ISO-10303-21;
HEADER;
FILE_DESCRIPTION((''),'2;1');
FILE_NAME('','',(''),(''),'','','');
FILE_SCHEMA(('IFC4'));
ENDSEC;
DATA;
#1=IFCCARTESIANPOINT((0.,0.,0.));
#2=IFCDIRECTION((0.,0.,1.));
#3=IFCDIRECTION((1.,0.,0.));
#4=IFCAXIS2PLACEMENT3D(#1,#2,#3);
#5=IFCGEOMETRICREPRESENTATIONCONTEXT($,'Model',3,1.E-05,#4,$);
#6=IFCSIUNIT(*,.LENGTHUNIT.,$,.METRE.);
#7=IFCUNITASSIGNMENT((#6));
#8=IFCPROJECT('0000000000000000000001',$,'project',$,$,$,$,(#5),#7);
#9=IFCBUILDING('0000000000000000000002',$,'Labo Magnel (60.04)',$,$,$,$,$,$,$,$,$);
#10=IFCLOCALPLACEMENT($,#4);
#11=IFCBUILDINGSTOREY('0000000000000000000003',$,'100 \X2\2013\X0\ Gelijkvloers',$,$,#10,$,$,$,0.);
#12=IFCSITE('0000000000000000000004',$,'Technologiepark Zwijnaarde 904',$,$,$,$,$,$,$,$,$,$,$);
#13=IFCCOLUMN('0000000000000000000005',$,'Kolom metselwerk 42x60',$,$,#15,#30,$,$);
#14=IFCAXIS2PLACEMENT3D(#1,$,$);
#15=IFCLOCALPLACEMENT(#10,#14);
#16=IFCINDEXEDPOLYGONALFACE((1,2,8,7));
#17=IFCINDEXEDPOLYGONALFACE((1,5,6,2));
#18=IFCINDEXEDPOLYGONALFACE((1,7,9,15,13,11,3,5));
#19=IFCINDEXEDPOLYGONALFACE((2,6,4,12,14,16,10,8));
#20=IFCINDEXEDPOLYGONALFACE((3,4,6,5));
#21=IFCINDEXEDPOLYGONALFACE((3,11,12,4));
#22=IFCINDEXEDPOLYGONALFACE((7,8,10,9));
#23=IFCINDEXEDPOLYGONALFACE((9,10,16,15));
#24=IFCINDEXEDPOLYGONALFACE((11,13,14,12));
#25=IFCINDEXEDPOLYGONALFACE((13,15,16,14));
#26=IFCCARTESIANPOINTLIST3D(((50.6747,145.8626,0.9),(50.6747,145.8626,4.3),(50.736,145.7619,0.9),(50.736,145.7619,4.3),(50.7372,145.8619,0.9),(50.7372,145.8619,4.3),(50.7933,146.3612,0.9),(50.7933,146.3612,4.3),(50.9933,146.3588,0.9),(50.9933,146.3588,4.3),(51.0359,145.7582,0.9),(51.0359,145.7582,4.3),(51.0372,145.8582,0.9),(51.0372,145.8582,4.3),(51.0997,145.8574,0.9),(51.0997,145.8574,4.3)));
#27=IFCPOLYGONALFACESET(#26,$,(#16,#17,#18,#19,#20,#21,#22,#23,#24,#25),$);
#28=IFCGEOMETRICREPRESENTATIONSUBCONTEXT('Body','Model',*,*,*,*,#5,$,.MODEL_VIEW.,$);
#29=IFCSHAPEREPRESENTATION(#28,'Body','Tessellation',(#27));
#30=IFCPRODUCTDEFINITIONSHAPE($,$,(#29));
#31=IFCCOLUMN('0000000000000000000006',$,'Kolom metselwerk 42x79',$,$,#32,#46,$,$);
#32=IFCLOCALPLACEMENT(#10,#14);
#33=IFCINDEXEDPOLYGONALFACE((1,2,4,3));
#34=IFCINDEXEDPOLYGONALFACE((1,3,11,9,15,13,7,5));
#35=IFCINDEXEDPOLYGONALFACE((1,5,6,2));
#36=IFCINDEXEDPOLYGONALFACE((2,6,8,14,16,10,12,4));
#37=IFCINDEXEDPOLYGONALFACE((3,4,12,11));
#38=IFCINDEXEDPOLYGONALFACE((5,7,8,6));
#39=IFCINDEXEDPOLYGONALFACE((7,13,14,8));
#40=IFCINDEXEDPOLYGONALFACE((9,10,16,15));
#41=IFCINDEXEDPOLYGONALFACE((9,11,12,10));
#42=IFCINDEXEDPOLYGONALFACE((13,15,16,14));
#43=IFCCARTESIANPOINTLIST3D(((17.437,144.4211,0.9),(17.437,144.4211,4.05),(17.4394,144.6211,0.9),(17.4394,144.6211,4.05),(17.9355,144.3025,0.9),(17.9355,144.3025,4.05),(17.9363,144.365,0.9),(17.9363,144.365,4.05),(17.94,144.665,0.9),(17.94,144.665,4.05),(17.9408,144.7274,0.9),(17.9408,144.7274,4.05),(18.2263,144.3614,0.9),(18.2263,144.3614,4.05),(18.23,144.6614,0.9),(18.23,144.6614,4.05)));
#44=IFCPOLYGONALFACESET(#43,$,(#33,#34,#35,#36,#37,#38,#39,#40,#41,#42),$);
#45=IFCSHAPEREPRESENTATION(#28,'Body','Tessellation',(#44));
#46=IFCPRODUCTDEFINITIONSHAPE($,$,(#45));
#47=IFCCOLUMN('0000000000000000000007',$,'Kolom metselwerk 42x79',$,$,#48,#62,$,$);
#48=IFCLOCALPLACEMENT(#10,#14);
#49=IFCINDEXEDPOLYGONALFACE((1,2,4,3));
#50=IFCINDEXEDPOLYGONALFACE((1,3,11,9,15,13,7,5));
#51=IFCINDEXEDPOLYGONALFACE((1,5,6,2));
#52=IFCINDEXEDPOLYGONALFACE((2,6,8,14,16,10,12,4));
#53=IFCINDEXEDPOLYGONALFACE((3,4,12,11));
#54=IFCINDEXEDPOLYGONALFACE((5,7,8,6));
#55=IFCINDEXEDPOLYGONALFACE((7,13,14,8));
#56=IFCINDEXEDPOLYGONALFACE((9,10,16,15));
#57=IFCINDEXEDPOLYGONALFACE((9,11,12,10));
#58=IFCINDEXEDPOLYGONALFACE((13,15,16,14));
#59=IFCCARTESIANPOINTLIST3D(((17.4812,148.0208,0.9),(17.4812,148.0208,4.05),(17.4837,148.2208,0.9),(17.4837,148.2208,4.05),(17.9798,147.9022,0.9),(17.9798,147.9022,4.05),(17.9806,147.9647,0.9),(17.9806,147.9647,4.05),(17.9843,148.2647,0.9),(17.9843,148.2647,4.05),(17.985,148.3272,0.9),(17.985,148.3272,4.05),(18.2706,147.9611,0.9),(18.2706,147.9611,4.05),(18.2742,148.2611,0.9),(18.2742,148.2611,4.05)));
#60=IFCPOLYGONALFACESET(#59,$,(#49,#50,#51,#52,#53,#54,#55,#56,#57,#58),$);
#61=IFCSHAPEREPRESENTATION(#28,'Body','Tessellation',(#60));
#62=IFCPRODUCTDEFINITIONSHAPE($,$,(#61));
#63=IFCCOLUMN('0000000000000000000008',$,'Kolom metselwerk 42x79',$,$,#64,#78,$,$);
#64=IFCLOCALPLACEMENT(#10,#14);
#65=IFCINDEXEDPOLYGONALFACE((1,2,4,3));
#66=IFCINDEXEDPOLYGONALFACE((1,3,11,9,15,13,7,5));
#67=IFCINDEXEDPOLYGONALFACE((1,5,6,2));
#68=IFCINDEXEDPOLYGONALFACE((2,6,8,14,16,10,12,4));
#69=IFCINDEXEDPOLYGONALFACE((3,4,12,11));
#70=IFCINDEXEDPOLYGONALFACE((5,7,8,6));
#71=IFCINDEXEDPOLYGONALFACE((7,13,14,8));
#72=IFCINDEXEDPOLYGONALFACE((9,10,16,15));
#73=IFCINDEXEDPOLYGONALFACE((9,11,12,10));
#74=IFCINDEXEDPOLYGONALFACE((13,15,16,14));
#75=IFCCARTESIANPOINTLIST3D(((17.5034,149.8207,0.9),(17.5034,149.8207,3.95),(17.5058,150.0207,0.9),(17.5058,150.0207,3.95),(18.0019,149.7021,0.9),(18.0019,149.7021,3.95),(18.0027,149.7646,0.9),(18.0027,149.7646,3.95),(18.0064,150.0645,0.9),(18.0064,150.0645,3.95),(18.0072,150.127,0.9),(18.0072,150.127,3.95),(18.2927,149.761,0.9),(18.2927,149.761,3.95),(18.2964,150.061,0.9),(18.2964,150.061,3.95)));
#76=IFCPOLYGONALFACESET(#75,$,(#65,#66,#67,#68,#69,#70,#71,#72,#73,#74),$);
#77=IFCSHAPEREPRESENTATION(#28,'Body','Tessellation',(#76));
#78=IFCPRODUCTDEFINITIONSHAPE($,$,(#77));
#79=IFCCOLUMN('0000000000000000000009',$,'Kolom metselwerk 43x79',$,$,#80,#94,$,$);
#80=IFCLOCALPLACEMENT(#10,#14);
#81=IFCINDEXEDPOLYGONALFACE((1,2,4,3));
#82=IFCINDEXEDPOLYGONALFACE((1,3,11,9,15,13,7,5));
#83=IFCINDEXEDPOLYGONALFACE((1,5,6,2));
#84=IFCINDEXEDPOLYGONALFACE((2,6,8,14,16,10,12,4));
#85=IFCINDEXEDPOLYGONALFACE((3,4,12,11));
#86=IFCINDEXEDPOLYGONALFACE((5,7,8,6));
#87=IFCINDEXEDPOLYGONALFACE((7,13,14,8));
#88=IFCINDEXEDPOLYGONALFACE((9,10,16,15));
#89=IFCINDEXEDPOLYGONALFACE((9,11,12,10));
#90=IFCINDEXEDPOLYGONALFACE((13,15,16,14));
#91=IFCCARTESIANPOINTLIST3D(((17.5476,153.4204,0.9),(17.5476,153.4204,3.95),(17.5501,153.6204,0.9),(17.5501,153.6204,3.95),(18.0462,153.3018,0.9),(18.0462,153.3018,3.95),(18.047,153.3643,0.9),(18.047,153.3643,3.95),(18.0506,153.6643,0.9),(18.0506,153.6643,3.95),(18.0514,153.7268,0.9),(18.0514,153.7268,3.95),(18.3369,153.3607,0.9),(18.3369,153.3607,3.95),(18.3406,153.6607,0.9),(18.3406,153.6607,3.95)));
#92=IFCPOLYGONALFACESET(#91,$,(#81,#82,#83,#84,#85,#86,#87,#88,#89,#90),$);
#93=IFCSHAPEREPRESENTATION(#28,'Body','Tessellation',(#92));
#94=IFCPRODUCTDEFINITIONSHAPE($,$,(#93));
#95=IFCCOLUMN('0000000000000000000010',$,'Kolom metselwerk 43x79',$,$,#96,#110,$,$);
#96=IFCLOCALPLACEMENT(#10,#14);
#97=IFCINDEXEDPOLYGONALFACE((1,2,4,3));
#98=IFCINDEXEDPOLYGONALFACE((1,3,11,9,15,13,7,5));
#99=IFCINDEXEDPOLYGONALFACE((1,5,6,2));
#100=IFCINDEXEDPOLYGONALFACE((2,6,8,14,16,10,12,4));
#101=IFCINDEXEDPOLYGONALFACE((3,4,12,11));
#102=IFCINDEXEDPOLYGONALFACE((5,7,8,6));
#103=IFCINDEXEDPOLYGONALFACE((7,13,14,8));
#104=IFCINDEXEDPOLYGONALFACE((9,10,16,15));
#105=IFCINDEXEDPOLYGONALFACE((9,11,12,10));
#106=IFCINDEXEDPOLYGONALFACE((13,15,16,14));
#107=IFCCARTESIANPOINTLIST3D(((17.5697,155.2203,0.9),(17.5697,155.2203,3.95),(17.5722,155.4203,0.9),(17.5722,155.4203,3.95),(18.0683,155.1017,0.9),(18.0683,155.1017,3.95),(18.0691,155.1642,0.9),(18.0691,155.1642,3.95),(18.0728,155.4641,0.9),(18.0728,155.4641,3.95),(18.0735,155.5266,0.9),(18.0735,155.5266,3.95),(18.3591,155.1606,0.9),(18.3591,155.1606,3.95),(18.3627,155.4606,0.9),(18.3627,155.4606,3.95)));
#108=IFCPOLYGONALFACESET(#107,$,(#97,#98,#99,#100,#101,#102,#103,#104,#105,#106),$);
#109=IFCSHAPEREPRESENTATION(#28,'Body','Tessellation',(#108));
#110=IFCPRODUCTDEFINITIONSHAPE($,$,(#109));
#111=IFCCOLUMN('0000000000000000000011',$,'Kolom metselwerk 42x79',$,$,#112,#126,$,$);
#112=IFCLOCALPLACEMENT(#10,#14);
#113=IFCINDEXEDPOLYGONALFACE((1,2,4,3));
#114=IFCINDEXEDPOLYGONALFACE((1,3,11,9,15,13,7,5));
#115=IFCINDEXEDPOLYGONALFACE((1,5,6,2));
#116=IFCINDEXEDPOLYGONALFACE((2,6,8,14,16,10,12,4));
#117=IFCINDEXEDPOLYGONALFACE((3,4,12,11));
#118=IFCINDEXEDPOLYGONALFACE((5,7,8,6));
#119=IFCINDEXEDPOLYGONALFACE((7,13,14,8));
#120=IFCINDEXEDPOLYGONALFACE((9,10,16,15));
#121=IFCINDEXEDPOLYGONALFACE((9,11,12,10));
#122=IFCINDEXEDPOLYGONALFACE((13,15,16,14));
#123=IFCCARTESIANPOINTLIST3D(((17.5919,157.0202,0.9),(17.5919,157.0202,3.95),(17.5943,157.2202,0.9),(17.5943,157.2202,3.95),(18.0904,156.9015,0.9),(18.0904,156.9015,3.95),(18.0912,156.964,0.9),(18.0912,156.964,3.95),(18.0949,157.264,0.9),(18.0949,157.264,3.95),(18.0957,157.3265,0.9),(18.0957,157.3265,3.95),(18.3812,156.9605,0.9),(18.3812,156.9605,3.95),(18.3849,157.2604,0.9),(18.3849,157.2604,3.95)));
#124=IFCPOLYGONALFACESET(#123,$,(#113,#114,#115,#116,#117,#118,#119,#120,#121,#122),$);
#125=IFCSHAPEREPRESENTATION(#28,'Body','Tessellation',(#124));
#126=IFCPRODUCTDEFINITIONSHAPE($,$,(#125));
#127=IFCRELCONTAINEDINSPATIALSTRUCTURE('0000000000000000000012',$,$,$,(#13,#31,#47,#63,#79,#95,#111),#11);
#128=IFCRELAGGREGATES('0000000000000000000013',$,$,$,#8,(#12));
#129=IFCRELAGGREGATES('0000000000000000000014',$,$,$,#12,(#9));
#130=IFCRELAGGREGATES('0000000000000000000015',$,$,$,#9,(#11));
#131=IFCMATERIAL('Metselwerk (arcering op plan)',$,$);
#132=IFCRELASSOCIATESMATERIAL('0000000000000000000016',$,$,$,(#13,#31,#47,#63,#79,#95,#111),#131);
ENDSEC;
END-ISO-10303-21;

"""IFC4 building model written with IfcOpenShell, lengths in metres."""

from ifc_helpers import new_model, si_unit, frame, origin, origin_with_axes, place, context, subcontext, project, spatial, polyline, outline, extrude, material, element, save


model = new_model("IFC4")

# Units and contexts
model_context = context("Model", 3, precision=1e-05, world=origin_with_axes())
body_context = subcontext(model_context, "Body", "Model", "MODEL_VIEW")
ifc_project = project(units=[si_unit("LENGTHUNIT", "METRE")], contexts=[model_context])

# Site, building, storey
site = spatial("IfcSite", under=ifc_project, Name="Technologiepark Zwijnaarde 904")
building = spatial("IfcBuilding", under=site, Name="Labo Magnel (60.04)")
storey_placement = place(None, origin_with_axes())
storey = spatial("IfcBuildingStorey", under=building, at=storey_placement, Name="100 – Gelijkvloers", Elevation=0.0)

# Columns
ifc_material_1 = material(Name="Metselwerk (arcering op plan)")
column_1_placement = place(storey_placement, frame((0.0, 0.0, 0.9), z_axis=(0.0, 0.0, 1.0), x_axis=(1.0, 0.0, 0.0)))
element("IfcColumn", 1, at=column_1_placement, inside=storey, material=ifc_material_1, Name="Kolom metselwerk 42x60", context=body_context, shape_type="SweptSolid", body=[
    extrude(outline(polyline([(50.9933, 146.3588), (50.7933, 146.3612), (50.6747, 145.8626), (50.7372, 145.8619), (50.736, 145.7619), (51.0359, 145.7582), (51.0372, 145.8582), (51.0997, 145.8574), (50.9933, 146.3588)])), origin(), (0.0, 0.0, 1.0), 3.4),
])
column_2_placement = place(storey_placement, frame((0.0, 0.0, 0.9), z_axis=(0.0, 0.0, 1.0), x_axis=(1.0, 0.0, 0.0)))
element("IfcColumn", 2, at=column_2_placement, inside=storey, material=ifc_material_1, Name="Kolom metselwerk 42x79", context=body_context, shape_type="SweptSolid", body=[
    extrude(outline(polyline([(18.23, 144.6614), (17.94, 144.665), (17.9408, 144.7274), (17.4394, 144.6211), (17.437, 144.4211), (17.9355, 144.3025), (17.9363, 144.365), (18.2263, 144.3614), (18.23, 144.6614)])), origin(), (0.0, 0.0, 1.0), 3.15),
])
column_3_placement = place(storey_placement, frame((0.0, 0.0, 0.9), z_axis=(0.0, 0.0, 1.0), x_axis=(1.0, 0.0, 0.0)))
element("IfcColumn", 3, at=column_3_placement, inside=storey, material=ifc_material_1, Name="Kolom metselwerk 42x79", context=body_context, shape_type="SweptSolid", body=[
    extrude(outline(polyline([(18.2742, 148.2611), (17.9843, 148.2647), (17.985, 148.3272), (17.4837, 148.2208), (17.4812, 148.0208), (17.9798, 147.9022), (17.9806, 147.9647), (18.2706, 147.9611), (18.2742, 148.2611)])), origin(), (0.0, 0.0, 1.0), 3.15),
])
column_4_placement = place(storey_placement, frame((0.0, 0.0, 0.9), z_axis=(0.0, 0.0, 1.0), x_axis=(1.0, 0.0, 0.0)))
element("IfcColumn", 4, at=column_4_placement, inside=storey, material=ifc_material_1, Name="Kolom metselwerk 42x79", context=body_context, shape_type="SweptSolid", body=[
    extrude(outline(polyline([(18.2964, 150.061), (18.0064, 150.0645), (18.0072, 150.127), (17.5058, 150.0207), (17.5034, 149.8207), (18.0019, 149.7021), (18.0027, 149.7646), (18.2927, 149.761), (18.2964, 150.061)])), origin(), (0.0, 0.0, 1.0), 3.05),
])
column_5_placement = place(storey_placement, frame((0.0, 0.0, 0.9), z_axis=(0.0, 0.0, 1.0), x_axis=(1.0, 0.0, 0.0)))
element("IfcColumn", 5, at=column_5_placement, inside=storey, material=ifc_material_1, Name="Kolom metselwerk 43x79", context=body_context, shape_type="SweptSolid", body=[
    extrude(outline(polyline([(18.3406, 153.6607), (18.0506, 153.6643), (18.0514, 153.7268), (17.5501, 153.6204), (17.5476, 153.4204), (18.0462, 153.3018), (18.047, 153.3643), (18.3369, 153.3607), (18.3406, 153.6607)])), origin(), (0.0, 0.0, 1.0), 3.05),
])
column_6_placement = place(storey_placement, frame((0.0, 0.0, 0.9), z_axis=(0.0, 0.0, 1.0), x_axis=(1.0, 0.0, 0.0)))
element("IfcColumn", 6, at=column_6_placement, inside=storey, material=ifc_material_1, Name="Kolom metselwerk 43x79", context=body_context, shape_type="SweptSolid", body=[
    extrude(outline(polyline([(18.3627, 155.4606), (18.0728, 155.4641), (18.0735, 155.5266), (17.5722, 155.4203), (17.5697, 155.2203), (18.0683, 155.1017), (18.0691, 155.1642), (18.3591, 155.1606), (18.3627, 155.4606)])), origin(), (0.0, 0.0, 1.0), 3.05),
])
column_7_placement = place(storey_placement, frame((0.0, 0.0, 0.9), z_axis=(0.0, 0.0, 1.0), x_axis=(1.0, 0.0, 0.0)))
element("IfcColumn", 7, at=column_7_placement, inside=storey, material=ifc_material_1, Name="Kolom metselwerk 42x79", context=body_context, shape_type="SweptSolid", body=[
    extrude(outline(polyline([(18.3849, 157.2604), (18.0949, 157.264), (18.0957, 157.3265), (17.5943, 157.2202), (17.5919, 157.0202), (18.0904, 156.9015), (18.0912, 156.964), (18.3812, 156.9605), (18.3849, 157.2604)])), origin(), (0.0, 0.0, 1.0), 3.05),
])

save(model, "model.ifc")
